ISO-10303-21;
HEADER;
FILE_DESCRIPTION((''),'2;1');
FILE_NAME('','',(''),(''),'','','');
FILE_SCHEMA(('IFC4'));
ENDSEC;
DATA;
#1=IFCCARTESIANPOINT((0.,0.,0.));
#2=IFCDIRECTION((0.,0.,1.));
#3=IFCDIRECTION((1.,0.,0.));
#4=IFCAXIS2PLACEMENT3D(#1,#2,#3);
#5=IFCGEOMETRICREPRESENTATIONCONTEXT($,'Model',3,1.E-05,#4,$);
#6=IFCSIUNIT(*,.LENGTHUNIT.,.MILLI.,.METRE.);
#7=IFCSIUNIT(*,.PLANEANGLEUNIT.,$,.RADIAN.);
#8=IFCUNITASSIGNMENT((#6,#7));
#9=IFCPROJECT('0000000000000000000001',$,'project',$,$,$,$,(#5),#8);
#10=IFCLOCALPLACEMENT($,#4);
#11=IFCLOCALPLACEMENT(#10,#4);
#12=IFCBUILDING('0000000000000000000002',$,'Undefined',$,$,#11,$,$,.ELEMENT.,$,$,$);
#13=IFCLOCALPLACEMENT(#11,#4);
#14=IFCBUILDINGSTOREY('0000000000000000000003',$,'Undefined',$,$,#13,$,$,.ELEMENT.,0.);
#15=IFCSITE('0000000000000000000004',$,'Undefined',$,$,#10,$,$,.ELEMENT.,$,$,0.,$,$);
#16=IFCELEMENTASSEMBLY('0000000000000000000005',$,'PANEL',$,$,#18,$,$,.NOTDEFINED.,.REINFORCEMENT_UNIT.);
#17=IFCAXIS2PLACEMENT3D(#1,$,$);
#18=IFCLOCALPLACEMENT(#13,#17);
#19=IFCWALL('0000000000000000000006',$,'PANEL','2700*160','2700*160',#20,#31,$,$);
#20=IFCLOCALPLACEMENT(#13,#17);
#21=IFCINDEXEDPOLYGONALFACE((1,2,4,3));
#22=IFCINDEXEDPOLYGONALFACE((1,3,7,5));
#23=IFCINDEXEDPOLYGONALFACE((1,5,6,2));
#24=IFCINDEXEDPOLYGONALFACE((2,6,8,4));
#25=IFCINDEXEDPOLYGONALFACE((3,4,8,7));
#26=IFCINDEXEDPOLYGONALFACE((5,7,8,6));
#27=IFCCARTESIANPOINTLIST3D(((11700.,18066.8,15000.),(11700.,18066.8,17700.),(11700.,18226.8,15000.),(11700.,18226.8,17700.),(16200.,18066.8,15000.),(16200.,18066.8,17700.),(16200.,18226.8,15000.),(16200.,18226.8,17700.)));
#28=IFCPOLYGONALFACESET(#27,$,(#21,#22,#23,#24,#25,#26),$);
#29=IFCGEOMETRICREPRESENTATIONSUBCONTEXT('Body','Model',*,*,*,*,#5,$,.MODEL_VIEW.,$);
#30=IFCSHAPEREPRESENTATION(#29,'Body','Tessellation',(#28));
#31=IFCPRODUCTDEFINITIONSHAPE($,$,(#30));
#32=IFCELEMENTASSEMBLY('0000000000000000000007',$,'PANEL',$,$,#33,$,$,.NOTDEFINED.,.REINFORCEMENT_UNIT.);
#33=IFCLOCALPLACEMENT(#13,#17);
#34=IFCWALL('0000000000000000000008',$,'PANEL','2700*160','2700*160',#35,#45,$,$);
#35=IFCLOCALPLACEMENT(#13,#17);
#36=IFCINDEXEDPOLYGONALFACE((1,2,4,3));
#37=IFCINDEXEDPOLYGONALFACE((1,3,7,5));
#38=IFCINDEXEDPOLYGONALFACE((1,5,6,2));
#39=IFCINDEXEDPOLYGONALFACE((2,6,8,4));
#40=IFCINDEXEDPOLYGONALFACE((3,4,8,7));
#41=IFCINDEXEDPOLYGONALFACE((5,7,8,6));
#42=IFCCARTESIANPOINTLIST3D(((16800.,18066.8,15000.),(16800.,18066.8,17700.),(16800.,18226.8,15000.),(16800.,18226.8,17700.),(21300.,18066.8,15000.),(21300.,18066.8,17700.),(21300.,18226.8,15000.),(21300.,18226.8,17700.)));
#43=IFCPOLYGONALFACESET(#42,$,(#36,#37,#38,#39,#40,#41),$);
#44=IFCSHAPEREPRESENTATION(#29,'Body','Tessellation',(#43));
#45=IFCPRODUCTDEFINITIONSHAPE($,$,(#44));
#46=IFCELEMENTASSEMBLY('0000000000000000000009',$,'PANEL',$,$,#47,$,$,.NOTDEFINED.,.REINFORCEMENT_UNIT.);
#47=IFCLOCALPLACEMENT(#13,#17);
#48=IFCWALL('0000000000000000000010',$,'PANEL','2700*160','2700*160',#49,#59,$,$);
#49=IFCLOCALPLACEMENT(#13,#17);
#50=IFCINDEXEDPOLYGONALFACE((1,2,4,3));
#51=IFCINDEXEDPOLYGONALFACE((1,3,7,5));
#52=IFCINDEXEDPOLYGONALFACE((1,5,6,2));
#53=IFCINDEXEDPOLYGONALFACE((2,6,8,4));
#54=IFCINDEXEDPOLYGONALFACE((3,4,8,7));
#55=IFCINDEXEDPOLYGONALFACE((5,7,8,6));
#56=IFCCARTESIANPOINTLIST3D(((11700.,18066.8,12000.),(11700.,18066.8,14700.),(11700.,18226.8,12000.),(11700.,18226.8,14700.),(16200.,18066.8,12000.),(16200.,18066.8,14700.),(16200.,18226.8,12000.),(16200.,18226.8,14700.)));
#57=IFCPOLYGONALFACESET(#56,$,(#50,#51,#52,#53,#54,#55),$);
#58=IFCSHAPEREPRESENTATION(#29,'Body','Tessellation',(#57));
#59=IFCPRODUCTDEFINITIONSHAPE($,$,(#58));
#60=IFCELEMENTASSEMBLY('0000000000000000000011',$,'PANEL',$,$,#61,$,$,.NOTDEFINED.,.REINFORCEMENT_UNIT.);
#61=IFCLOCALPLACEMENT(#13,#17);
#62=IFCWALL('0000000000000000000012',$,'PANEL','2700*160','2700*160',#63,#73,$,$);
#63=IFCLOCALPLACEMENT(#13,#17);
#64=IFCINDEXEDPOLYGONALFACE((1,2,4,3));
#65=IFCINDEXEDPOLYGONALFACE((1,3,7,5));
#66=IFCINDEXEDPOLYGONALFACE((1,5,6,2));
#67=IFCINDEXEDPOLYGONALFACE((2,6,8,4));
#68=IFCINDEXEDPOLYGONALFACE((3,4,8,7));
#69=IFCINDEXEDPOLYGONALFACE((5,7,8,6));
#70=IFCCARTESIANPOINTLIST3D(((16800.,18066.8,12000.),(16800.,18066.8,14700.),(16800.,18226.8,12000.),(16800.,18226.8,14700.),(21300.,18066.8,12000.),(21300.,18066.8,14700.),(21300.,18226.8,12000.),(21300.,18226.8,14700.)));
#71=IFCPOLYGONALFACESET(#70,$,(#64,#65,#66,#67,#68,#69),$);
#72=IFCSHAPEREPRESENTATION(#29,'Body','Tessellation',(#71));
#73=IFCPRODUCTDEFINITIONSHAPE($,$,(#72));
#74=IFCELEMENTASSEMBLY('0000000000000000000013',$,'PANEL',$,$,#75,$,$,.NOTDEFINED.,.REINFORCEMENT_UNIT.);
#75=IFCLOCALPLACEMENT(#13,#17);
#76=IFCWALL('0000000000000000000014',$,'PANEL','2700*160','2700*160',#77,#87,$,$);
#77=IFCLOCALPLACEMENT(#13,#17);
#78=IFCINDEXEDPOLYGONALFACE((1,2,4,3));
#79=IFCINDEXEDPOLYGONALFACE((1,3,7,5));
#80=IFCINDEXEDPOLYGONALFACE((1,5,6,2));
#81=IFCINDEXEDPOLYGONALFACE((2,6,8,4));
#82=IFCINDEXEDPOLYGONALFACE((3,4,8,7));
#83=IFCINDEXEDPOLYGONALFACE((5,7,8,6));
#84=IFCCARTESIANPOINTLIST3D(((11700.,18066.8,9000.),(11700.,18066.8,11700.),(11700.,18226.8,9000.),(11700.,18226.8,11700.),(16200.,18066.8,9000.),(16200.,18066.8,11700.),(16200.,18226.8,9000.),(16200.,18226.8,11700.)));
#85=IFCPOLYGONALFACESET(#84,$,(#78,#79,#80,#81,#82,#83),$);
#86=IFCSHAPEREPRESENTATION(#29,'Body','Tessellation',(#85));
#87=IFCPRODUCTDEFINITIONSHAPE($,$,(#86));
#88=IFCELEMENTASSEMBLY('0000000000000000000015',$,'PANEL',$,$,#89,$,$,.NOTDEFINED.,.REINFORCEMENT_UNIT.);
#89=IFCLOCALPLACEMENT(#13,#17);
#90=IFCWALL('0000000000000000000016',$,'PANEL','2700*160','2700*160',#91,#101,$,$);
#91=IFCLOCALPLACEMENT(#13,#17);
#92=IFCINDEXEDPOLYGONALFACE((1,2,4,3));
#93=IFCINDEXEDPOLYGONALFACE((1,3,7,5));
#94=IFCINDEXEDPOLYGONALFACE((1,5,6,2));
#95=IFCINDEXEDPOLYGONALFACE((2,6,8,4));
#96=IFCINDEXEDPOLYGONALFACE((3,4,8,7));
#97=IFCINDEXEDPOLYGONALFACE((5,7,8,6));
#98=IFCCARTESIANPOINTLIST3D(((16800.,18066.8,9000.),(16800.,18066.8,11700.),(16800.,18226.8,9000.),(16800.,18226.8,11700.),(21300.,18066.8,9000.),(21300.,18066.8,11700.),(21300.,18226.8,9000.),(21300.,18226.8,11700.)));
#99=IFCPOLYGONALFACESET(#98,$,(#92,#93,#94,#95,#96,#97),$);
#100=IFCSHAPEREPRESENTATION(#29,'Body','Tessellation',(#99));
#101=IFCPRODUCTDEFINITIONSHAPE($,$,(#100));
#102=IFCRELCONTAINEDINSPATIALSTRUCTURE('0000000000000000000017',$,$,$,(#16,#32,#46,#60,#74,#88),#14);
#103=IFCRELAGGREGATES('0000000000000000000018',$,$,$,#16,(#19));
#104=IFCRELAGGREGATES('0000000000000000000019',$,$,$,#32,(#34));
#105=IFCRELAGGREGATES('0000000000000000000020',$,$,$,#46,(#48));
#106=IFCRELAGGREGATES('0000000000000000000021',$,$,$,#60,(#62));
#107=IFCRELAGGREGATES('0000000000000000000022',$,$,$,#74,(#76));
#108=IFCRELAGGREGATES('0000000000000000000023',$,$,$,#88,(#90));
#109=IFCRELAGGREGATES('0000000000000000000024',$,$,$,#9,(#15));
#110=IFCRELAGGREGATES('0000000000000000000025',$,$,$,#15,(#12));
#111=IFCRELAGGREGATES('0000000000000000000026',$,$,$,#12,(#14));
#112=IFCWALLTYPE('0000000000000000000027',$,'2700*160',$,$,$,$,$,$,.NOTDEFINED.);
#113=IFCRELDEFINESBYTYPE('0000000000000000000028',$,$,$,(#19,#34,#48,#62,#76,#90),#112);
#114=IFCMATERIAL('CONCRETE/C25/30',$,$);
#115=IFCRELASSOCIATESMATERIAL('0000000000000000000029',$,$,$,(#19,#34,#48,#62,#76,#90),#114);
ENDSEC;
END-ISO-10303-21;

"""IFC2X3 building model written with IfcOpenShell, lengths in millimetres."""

from ifc_helpers import new_model, si_unit, frame, frame_2d, origin_with_axes, place, context, subcontext, project, spatial, rectangle, extrude, material, type_object, element, aggregate, save


model = new_model("IFC2X3")

# Units and contexts
model_context = context("Model", 3, precision=1e-05, world=origin_with_axes())
body_context = subcontext(model_context, "Body", "Model", "MODEL_VIEW")
ifc_project = project(units=[si_unit("LENGTHUNIT", "METRE", prefix="MILLI"), si_unit("PLANEANGLEUNIT", "RADIAN")], contexts=[model_context])

# Site, building, storey
site_placement = place(None, origin_with_axes())
site = spatial("IfcSite", under=ifc_project, at=site_placement, Name="Undefined", CompositionType="ELEMENT", RefElevation=0.0)
building_placement = place(site_placement, origin_with_axes())
building = spatial("IfcBuilding", under=site, at=building_placement, Name="Undefined", CompositionType="ELEMENT")
storey_placement = place(building_placement, origin_with_axes())
storey = spatial("IfcBuildingStorey", under=building, at=storey_placement, Name="Undefined", CompositionType="ELEMENT", Elevation=0.0)

# Shared definitions
ifc_material = material(Name="CONCRETE/C25/30")

# Element assemblies, walls
assembly_1_placement = place(storey_placement, origin_with_axes())
assembly_1 = element("IfcElementAssembly", 1, at=assembly_1_placement, inside=storey, Name="PANEL", AssemblyPlace="NOTDEFINED", PredefinedType="REINFORCEMENT_UNIT")
wall_type = type_object("IfcWallType", Name="2700*160", PredefinedType="NOTDEFINED")
wall_1_placement = place(assembly_1_placement, frame((11700.0, 18146.8, 15000.0), z_axis=(0.0, 0.0, 1.0), x_axis=(1.0, 0.0, 0.0)))
wall_1 = element("IfcWall", 2, at=wall_1_placement, type_object=wall_type, material=ifc_material, Name="PANEL", Description="2700*160", ObjectType="2700*160", context=body_context, shape_type="SweptSolid", body=[
    extrude(rectangle(XDim=4500.0, YDim=160.0, at=frame_2d((0.0, 2250.0), x_axis=(0.0, -1.0))), frame((0.0, 0.0, 0.0), z_axis=(0.0, 0.0, 1.0), x_axis=(0.0, -1.0, 0.0)), (0.0, 0.0, 1.0), 2700.0),
])
aggregate(assembly_1, [wall_1])
assembly_2_placement = place(storey_placement, origin_with_axes())
assembly_2 = element("IfcElementAssembly", 3, at=assembly_2_placement, inside=storey, Name="PANEL", AssemblyPlace="NOTDEFINED", PredefinedType="REINFORCEMENT_UNIT")
wall_2_placement = place(assembly_2_placement, frame((16800.0, 18146.8, 15000.0), z_axis=(0.0, 0.0, 1.0), x_axis=(1.0, 0.0, 0.0)))
wall_2 = element("IfcWall", 4, at=wall_2_placement, type_object=wall_type, material=ifc_material, Name="PANEL", Description="2700*160", ObjectType="2700*160", context=body_context, shape_type="SweptSolid", body=[
    extrude(rectangle(XDim=4500.0, YDim=160.0, at=frame_2d((0.0, 2250.0), x_axis=(0.0, -1.0))), frame((0.0, 0.0, 0.0), z_axis=(0.0, 0.0, 1.0), x_axis=(0.0, -1.0, 0.0)), (0.0, 0.0, 1.0), 2700.0),
])
aggregate(assembly_2, [wall_2])
assembly_3_placement = place(storey_placement, origin_with_axes())
assembly_3 = element("IfcElementAssembly", 5, at=assembly_3_placement, inside=storey, Name="PANEL", AssemblyPlace="NOTDEFINED", PredefinedType="REINFORCEMENT_UNIT")
wall_3_placement = place(assembly_3_placement, frame((11700.0, 18146.8, 12000.0), z_axis=(0.0, 0.0, 1.0), x_axis=(1.0, 0.0, 0.0)))
wall_3 = element("IfcWall", 6, at=wall_3_placement, type_object=wall_type, material=ifc_material, Name="PANEL", Description="2700*160", ObjectType="2700*160", context=body_context, shape_type="SweptSolid", body=[
    extrude(rectangle(XDim=4500.0, YDim=160.0, at=frame_2d((0.0, 2250.0), x_axis=(0.0, -1.0))), frame((0.0, 0.0, 0.0), z_axis=(0.0, 0.0, 1.0), x_axis=(0.0, -1.0, 0.0)), (0.0, 0.0, 1.0), 2700.0),
])
aggregate(assembly_3, [wall_3])
assembly_4_placement = place(storey_placement, origin_with_axes())
assembly_4 = element("IfcElementAssembly", 7, at=assembly_4_placement, inside=storey, Name="PANEL", AssemblyPlace="NOTDEFINED", PredefinedType="REINFORCEMENT_UNIT")
wall_4_placement = place(assembly_4_placement, frame((16800.0, 18146.8, 12000.0), z_axis=(0.0, 0.0, 1.0), x_axis=(1.0, 0.0, 0.0)))
wall_4 = element("IfcWall", 8, at=wall_4_placement, type_object=wall_type, material=ifc_material, Name="PANEL", Description="2700*160", ObjectType="2700*160", context=body_context, shape_type="SweptSolid", body=[
    extrude(rectangle(XDim=4500.0, YDim=160.0, at=frame_2d((0.0, 2250.0), x_axis=(0.0, -1.0))), frame((0.0, 0.0, 0.0), z_axis=(0.0, 0.0, 1.0), x_axis=(0.0, -1.0, 0.0)), (0.0, 0.0, 1.0), 2700.0),
])
aggregate(assembly_4, [wall_4])
assembly_5_placement = place(storey_placement, origin_with_axes())
assembly_5 = element("IfcElementAssembly", 9, at=assembly_5_placement, inside=storey, Name="PANEL", AssemblyPlace="NOTDEFINED", PredefinedType="REINFORCEMENT_UNIT")
wall_5_placement = place(assembly_5_placement, frame((11700.0, 18146.8, 9000.0), z_axis=(0.0, 0.0, 1.0), x_axis=(1.0, 0.0, 0.0)))
wall_5 = element("IfcWall", 10, at=wall_5_placement, type_object=wall_type, material=ifc_material, Name="PANEL", Description="2700*160", ObjectType="2700*160", context=body_context, shape_type="SweptSolid", body=[
    extrude(rectangle(XDim=4500.0, YDim=160.0, at=frame_2d((0.0, 2250.0), x_axis=(0.0, -1.0))), frame((0.0, 0.0, 0.0), z_axis=(0.0, 0.0, 1.0), x_axis=(0.0, -1.0, 0.0)), (0.0, 0.0, 1.0), 2700.0),
])
aggregate(assembly_5, [wall_5])
assembly_6_placement = place(storey_placement, origin_with_axes())
assembly_6 = element("IfcElementAssembly", 11, at=assembly_6_placement, inside=storey, Name="PANEL", AssemblyPlace="NOTDEFINED", PredefinedType="REINFORCEMENT_UNIT")
wall_6_placement = place(assembly_6_placement, frame((16800.0, 18146.8, 9000.0), z_axis=(0.0, 0.0, 1.0), x_axis=(1.0, 0.0, 0.0)))
wall_6 = element("IfcWall", 12, at=wall_6_placement, type_object=wall_type, material=ifc_material, Name="PANEL", Description="2700*160", ObjectType="2700*160", context=body_context, shape_type="SweptSolid", body=[
    extrude(rectangle(XDim=4500.0, YDim=160.0, at=frame_2d((0.0, 2250.0), x_axis=(0.0, -1.0))), frame((0.0, 0.0, 0.0), z_axis=(0.0, 0.0, 1.0), x_axis=(0.0, -1.0, 0.0)), (0.0, 0.0, 1.0), 2700.0),
])
aggregate(assembly_6, [wall_6])

save(model, "model.ifc")
